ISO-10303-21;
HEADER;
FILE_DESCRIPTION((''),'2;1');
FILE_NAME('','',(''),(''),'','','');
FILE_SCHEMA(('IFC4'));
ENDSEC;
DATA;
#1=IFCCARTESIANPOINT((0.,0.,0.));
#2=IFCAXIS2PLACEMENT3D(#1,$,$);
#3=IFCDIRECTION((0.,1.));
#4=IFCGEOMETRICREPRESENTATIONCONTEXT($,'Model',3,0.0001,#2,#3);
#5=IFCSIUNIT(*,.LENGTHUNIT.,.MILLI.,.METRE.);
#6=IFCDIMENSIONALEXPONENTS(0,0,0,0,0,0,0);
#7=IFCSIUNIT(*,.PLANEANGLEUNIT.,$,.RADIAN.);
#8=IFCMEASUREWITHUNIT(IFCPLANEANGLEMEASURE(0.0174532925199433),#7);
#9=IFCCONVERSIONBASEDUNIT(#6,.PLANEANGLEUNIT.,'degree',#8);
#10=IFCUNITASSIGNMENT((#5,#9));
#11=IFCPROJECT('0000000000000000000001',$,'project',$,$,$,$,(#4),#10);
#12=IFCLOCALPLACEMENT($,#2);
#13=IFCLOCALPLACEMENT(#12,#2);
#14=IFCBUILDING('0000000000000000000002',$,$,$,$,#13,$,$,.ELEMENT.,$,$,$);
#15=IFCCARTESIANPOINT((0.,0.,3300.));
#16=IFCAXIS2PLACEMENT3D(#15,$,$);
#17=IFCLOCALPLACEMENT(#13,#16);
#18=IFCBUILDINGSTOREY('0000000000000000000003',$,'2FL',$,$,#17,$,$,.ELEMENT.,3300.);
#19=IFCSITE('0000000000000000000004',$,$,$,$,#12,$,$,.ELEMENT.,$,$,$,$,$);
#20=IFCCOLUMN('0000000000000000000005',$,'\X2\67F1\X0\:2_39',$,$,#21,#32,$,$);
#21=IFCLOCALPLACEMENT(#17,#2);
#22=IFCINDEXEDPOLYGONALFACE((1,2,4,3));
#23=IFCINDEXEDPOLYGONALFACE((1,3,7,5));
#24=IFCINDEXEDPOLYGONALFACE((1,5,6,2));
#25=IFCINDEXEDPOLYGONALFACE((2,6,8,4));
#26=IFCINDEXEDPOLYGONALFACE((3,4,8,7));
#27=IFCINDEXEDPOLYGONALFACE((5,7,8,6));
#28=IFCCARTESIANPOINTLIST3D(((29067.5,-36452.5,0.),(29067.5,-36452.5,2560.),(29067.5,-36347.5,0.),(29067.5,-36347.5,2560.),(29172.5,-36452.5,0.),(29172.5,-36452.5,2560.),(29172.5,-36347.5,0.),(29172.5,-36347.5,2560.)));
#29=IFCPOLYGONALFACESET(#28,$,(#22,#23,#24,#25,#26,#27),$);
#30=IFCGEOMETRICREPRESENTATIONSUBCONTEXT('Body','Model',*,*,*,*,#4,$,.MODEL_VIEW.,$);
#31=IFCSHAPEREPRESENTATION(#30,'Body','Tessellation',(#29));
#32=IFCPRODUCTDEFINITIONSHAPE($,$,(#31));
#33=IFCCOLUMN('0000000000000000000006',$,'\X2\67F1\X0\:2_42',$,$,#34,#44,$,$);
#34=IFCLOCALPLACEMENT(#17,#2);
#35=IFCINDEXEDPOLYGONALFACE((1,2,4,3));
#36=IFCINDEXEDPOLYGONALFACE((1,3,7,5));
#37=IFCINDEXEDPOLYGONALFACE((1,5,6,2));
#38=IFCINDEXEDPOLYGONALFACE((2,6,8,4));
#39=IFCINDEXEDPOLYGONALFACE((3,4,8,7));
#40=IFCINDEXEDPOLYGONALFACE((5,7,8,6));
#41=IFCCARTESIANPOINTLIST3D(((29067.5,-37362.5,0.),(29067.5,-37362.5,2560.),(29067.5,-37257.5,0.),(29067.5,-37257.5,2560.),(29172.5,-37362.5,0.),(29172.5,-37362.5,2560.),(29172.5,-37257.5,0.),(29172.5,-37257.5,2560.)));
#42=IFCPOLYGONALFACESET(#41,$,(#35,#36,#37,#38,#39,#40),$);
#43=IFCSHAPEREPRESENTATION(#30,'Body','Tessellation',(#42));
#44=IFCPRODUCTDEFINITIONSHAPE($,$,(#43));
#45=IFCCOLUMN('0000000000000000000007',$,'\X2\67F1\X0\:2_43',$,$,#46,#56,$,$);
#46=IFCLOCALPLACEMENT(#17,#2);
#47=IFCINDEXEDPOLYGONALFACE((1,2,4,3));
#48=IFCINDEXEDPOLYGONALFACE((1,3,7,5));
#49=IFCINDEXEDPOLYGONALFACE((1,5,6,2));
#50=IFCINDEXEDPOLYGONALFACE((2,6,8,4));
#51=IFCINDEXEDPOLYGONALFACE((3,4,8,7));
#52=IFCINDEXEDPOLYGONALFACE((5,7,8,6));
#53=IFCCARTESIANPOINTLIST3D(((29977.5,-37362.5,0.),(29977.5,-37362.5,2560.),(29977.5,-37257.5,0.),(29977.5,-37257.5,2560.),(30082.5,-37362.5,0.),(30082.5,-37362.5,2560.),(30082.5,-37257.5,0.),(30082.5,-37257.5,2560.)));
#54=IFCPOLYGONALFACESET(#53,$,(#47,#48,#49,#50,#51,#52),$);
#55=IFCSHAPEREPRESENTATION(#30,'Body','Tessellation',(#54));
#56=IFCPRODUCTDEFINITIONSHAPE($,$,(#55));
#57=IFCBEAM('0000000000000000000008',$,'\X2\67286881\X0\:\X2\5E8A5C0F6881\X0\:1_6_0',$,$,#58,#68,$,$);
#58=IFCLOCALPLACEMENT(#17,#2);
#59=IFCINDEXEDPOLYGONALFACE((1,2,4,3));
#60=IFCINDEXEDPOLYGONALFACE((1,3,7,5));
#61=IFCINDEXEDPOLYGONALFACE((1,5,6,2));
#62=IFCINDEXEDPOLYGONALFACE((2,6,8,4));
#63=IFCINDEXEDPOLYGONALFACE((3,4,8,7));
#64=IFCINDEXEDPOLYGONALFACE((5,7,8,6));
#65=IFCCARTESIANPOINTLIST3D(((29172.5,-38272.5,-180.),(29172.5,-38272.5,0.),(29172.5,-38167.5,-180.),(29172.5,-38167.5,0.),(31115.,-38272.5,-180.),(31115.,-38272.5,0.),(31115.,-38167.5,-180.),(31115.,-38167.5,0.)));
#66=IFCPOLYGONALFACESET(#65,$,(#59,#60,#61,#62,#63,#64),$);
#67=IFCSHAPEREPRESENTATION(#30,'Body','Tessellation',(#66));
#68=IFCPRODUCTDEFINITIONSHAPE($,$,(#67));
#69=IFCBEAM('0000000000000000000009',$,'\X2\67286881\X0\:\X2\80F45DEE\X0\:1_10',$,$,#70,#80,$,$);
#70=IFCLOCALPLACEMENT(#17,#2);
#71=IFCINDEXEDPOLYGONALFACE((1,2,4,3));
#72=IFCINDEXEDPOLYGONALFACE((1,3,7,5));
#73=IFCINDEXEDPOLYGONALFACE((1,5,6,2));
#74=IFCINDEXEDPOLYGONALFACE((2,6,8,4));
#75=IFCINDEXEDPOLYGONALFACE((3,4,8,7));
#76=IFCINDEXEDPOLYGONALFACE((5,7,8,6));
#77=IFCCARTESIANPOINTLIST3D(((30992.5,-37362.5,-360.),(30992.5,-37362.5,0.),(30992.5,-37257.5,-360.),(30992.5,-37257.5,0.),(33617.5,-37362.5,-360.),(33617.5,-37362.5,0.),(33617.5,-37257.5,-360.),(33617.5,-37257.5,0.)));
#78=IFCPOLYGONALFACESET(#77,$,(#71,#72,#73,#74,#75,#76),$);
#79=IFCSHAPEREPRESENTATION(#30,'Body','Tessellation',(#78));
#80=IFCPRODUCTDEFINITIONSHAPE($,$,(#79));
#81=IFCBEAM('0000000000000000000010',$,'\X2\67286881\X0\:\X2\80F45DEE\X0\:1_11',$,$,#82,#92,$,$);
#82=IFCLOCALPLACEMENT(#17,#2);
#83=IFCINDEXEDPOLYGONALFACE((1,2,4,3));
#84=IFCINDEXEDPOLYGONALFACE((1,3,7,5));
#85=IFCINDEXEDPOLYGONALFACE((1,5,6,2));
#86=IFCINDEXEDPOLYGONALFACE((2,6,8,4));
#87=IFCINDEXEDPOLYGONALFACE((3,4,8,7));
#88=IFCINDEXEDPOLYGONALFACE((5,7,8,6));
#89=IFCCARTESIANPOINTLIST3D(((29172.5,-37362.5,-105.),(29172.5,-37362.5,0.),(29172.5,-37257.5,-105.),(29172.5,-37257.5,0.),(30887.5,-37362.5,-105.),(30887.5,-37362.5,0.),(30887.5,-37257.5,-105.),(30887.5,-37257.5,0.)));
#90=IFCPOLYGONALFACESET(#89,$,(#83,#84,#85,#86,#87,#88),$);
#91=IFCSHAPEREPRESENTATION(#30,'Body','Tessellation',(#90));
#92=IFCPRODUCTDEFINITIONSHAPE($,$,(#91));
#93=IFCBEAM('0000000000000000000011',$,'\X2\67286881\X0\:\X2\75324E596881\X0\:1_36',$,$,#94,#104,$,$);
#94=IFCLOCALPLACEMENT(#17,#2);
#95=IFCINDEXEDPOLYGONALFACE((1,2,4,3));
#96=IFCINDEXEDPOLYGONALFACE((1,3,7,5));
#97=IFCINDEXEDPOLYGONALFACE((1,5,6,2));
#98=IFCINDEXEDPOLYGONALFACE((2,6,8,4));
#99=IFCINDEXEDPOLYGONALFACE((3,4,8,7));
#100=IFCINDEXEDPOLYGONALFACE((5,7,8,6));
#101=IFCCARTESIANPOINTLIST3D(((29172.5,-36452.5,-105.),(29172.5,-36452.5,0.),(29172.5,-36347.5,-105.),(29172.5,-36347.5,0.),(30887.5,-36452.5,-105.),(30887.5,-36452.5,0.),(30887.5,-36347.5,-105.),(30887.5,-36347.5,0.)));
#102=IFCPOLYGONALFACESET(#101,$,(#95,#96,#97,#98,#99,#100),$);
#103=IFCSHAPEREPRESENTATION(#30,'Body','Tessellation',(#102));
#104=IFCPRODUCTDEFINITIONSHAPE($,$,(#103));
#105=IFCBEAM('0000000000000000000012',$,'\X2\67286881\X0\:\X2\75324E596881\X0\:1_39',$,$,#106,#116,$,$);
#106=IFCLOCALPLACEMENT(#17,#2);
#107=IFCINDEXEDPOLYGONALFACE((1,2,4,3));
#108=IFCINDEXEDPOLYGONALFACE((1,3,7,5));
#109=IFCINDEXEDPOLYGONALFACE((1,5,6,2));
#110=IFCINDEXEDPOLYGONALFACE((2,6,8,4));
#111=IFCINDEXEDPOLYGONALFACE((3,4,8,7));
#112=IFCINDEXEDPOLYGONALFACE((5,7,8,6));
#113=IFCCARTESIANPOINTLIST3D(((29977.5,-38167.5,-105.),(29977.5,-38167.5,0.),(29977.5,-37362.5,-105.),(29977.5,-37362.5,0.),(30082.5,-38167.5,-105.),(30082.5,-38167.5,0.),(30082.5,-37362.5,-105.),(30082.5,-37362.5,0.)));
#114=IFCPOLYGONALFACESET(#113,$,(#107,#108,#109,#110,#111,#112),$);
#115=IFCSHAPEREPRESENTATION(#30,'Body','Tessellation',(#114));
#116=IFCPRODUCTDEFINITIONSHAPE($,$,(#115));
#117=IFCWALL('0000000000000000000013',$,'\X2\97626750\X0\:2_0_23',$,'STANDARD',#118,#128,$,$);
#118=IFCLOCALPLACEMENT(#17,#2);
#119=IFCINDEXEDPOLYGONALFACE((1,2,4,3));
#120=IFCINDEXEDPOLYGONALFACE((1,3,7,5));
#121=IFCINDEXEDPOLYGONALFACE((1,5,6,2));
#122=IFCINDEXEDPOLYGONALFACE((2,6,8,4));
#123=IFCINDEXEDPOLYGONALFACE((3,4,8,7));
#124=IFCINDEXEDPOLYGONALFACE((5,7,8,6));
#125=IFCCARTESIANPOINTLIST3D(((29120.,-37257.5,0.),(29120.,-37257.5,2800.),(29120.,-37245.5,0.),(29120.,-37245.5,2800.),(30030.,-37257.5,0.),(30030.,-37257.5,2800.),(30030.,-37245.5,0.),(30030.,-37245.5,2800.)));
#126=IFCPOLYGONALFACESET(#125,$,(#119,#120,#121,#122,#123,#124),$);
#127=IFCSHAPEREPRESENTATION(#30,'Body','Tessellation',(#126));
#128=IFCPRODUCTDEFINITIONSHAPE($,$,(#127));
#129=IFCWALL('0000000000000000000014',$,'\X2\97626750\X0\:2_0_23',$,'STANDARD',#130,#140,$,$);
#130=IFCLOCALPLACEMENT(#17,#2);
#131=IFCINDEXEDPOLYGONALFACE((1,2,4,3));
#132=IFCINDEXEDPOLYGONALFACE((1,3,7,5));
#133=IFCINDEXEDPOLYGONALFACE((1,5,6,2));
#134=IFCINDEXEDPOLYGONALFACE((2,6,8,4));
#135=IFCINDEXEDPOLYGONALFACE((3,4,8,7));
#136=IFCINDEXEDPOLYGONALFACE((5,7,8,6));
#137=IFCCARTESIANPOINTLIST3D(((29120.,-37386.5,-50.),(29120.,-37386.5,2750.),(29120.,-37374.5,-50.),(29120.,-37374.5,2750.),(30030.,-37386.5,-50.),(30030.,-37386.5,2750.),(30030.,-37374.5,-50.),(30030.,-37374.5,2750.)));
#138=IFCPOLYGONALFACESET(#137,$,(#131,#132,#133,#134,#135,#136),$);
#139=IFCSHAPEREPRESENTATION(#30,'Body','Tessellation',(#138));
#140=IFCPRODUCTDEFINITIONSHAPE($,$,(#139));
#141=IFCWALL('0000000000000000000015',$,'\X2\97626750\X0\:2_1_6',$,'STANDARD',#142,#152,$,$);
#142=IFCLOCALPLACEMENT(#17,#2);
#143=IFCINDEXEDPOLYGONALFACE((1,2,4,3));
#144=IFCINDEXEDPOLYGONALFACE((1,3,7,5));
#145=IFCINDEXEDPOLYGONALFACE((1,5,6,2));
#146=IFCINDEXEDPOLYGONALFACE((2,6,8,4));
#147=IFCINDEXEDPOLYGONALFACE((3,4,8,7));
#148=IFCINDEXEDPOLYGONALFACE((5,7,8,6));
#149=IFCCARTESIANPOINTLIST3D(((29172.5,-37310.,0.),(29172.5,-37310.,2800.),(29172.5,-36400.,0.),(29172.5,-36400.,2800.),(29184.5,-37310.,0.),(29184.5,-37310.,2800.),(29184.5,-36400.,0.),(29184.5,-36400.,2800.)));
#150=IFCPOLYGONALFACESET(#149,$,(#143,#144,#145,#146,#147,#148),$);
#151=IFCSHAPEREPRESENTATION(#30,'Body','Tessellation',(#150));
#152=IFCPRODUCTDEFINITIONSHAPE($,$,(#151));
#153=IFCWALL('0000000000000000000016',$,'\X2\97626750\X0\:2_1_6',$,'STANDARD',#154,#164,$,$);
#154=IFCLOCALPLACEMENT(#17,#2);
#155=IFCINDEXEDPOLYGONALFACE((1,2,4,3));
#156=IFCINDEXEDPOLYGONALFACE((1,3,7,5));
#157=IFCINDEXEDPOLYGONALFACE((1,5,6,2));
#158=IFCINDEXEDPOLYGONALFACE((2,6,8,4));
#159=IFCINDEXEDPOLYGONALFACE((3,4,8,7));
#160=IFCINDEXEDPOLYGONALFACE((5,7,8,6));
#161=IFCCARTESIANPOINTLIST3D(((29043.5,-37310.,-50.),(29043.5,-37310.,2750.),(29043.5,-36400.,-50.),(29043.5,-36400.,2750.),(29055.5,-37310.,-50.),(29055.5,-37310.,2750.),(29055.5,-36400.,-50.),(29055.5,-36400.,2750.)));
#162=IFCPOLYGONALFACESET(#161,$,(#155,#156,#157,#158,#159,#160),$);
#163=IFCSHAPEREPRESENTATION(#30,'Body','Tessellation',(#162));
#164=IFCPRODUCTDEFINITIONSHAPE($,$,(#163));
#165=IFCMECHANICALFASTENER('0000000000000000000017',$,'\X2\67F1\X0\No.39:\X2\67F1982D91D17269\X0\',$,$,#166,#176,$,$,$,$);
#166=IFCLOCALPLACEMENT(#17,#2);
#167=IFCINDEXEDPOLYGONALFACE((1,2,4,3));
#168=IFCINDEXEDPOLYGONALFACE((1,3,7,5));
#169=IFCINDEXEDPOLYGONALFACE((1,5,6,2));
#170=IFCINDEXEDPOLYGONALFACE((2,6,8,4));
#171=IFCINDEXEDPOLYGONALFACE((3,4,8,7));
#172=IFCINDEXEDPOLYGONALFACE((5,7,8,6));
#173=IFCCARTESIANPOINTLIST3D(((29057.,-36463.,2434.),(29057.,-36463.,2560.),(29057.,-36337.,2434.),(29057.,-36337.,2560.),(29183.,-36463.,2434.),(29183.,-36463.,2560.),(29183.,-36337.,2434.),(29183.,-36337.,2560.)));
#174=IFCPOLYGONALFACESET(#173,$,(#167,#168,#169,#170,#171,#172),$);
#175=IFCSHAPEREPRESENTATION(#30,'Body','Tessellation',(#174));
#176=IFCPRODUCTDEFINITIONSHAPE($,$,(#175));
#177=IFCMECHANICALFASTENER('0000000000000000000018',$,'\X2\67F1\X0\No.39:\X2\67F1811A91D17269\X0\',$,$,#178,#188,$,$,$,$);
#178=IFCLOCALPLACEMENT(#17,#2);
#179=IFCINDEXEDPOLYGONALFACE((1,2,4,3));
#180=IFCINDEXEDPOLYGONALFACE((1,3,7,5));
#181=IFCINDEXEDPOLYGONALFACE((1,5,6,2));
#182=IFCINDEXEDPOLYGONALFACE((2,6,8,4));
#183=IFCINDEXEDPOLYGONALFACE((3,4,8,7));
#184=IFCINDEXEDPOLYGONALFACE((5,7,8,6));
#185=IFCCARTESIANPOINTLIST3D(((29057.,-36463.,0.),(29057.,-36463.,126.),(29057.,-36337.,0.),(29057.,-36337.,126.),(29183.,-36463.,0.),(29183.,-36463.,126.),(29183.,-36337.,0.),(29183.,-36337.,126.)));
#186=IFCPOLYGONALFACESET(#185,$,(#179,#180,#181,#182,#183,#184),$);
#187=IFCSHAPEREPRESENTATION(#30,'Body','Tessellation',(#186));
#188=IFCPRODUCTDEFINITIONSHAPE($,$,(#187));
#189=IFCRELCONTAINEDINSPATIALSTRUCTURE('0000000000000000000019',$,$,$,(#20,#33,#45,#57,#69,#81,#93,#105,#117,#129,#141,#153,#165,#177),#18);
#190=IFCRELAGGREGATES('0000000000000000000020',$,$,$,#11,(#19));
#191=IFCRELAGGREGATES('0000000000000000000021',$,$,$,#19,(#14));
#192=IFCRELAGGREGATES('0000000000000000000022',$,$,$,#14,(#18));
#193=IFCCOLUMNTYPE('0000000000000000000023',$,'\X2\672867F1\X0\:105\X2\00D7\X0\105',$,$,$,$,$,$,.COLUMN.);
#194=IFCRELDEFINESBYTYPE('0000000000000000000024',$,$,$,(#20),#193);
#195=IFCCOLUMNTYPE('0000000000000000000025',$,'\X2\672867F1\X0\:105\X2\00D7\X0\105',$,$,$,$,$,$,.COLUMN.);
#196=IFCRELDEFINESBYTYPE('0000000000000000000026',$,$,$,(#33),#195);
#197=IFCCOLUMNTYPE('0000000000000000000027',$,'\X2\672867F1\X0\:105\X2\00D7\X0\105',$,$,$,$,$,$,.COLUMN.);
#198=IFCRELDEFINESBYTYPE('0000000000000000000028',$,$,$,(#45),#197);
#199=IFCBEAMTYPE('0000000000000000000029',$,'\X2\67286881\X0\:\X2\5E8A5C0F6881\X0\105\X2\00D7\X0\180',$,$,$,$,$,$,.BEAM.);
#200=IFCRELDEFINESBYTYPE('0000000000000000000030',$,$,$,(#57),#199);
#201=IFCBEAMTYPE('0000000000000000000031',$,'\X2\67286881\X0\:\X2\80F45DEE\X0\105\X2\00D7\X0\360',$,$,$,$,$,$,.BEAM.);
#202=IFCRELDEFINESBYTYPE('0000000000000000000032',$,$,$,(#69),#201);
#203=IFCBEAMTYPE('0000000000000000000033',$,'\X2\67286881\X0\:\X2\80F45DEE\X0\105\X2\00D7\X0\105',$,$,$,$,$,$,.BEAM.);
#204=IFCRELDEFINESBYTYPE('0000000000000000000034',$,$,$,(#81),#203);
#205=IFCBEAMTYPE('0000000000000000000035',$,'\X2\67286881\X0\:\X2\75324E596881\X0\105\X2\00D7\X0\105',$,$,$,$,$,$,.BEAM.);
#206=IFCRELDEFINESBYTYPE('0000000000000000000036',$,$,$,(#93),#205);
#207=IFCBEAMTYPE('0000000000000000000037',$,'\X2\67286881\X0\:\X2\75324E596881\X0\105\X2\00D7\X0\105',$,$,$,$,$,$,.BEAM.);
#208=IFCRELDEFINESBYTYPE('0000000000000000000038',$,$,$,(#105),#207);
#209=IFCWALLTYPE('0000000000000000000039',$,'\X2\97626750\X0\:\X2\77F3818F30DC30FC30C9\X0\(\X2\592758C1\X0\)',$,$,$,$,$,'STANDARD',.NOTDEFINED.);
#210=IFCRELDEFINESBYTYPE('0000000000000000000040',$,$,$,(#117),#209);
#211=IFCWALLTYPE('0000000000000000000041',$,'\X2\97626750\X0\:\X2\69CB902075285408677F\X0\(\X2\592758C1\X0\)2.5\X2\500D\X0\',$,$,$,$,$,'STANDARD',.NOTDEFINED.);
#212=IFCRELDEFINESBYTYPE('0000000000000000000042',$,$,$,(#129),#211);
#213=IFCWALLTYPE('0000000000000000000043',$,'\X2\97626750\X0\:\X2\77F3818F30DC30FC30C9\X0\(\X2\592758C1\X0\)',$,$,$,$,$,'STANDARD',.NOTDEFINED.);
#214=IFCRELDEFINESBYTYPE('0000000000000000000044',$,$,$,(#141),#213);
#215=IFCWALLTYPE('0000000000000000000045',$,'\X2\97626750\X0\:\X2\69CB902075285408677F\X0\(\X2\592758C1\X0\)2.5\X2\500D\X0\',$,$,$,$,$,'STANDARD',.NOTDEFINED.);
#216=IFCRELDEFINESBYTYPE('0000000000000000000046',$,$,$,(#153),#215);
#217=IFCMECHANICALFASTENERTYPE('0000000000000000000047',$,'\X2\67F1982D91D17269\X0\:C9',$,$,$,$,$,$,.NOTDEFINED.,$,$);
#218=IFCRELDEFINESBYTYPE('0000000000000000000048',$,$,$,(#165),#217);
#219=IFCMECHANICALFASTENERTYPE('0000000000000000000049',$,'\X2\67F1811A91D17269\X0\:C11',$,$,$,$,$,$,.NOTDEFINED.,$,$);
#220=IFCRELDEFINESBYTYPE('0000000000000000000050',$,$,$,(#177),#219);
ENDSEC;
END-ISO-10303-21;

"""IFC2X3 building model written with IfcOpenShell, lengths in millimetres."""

from ifc_helpers import new_model, entity, si_unit, converted_unit, direction, frame, origin, origin_with_axes, origin_2d, place, context, subcontext, project, spatial, polyline, rectangle, outline, extrude, type_object, element, save


model = new_model("IFC2X3")

# Units and contexts
model_context = context("Model", 3, precision=0.0001, world=origin(), true_north=direction((0.0, 1.0)))
body_context = subcontext(model_context, "Body", "Model", "MODEL_VIEW")
ifc_project = project(units=[si_unit("LENGTHUNIT", "METRE", prefix="MILLI"), converted_unit("PLANEANGLEUNIT", "degree", entity("IfcPlaneAngleMeasure", 0.0174532925199433), si_unit("PLANEANGLEUNIT", "RADIAN"), dimensions=[0, 0, 0, 0, 0, 0, 0])], contexts=[model_context])

# Site, building, storey
site_placement = place(None, origin())
site = spatial("IfcSite", under=ifc_project, at=site_placement, CompositionType="ELEMENT")
building_placement = place(site_placement, origin())
building = spatial("IfcBuilding", under=site, at=building_placement, CompositionType="ELEMENT")
storey_placement = place(building_placement, frame((0.0, 0.0, 3300.0)))
storey = spatial("IfcBuildingStorey", under=building, at=storey_placement, Name="2FL", CompositionType="ELEMENT", Elevation=3300.0)

# Columns
column_type_1 = type_object("IfcColumnType", Name="木柱:105×105", PredefinedType="COLUMN")
column_1_placement = place(storey_placement, frame((29120.0, -36400.0, 0.0)))
element("IfcColumn", 1, at=column_1_placement, inside=storey, type_object=column_type_1, Name="柱:2_39", context=body_context, shape_type="SweptSolid", body=[
    extrude(rectangle(XDim=105.0, YDim=105.0, at=origin_2d()), origin_with_axes(), (0.0, 0.0, 1.0), 2560.0),
])
column_type_2 = type_object("IfcColumnType", Name="木柱:105×105", PredefinedType="COLUMN")
column_2_placement = place(storey_placement, frame((29120.0, -37310.0, 0.0)))
element("IfcColumn", 2, at=column_2_placement, inside=storey, type_object=column_type_2, Name="柱:2_42", context=body_context, shape_type="SweptSolid", body=[
    extrude(rectangle(XDim=105.0, YDim=105.0, at=origin_2d()), origin_with_axes(), (0.0, 0.0, 1.0), 2560.0),
])
column_type_3 = type_object("IfcColumnType", Name="木柱:105×105", PredefinedType="COLUMN")
column_3_placement = place(storey_placement, frame((30030.0, -37310.0, 0.0)))
element("IfcColumn", 3, at=column_3_placement, inside=storey, type_object=column_type_3, Name="柱:2_43", context=body_context, shape_type="SweptSolid", body=[
    extrude(rectangle(XDim=105.0, YDim=105.0, at=origin_2d()), origin_with_axes(), (0.0, 0.0, 1.0), 2560.0),
])

# Beams
beam_type_1 = type_object("IfcBeamType", Name="木梁:床小梁105×180", PredefinedType="BEAM")
beam_1_placement = place(storey_placement, frame((29172.5, -38220.0, -90.0), z_axis=(1.0, 0.0, 0.0), x_axis=(0.0, 1.0, 0.0)))
element("IfcBeam", 4, at=beam_1_placement, inside=storey, type_object=beam_type_1, Name="木梁:床小梁:1_6_0", context=body_context, shape_type="SweptSolid", body=[
    extrude(rectangle(XDim=105.0, YDim=180.0, at=origin_2d()), origin_with_axes(), (0.0, 0.0, 1.0), 1942.5),
])
beam_type_2 = type_object("IfcBeamType", Name="木梁:胴差105×360", PredefinedType="BEAM")
beam_2_placement = place(storey_placement, frame((30992.5, -37310.0, -180.0), z_axis=(1.0, 0.0, 0.0), x_axis=(0.0, 1.0, 0.0)))
element("IfcBeam", 5, at=beam_2_placement, inside=storey, type_object=beam_type_2, Name="木梁:胴差:1_10", context=body_context, shape_type="SweptSolid", body=[
    extrude(rectangle(XDim=105.0, YDim=360.0, at=origin_2d()), origin_with_axes(), (0.0, 0.0, 1.0), 2625.0),
])
beam_type_3 = type_object("IfcBeamType", Name="木梁:胴差105×105", PredefinedType="BEAM")
beam_3_placement = place(storey_placement, frame((29172.5, -37310.0, -52.5), z_axis=(1.0, 0.0, 0.0), x_axis=(0.0, 1.0, 0.0)))
element("IfcBeam", 6, at=beam_3_placement, inside=storey, type_object=beam_type_3, Name="木梁:胴差:1_11", context=body_context, shape_type="SweptSolid", body=[
    extrude(rectangle(XDim=105.0, YDim=105.0, at=origin_2d()), origin_with_axes(), (0.0, 0.0, 1.0), 1715.0),
])
beam_type_4 = type_object("IfcBeamType", Name="木梁:甲乙梁105×105", PredefinedType="BEAM")
beam_4_placement = place(storey_placement, frame((29172.5, -36400.0, -52.5), z_axis=(1.0, 0.0, 0.0), x_axis=(0.0, 1.0, 0.0)))
element("IfcBeam", 7, at=beam_4_placement, inside=storey, type_object=beam_type_4, Name="木梁:甲乙梁:1_36", context=body_context, shape_type="SweptSolid", body=[
    extrude(rectangle(XDim=105.0, YDim=105.0, at=origin_2d()), origin_with_axes(), (0.0, 0.0, 1.0), 1715.0),
])
beam_type_5 = type_object("IfcBeamType", Name="木梁:甲乙梁105×105", PredefinedType="BEAM")
beam_5_placement = place(storey_placement, frame((30030.0, -37362.5, -52.5), z_axis=(0.0, -1.0, 0.0), x_axis=(1.0, 0.0, 0.0)))
element("IfcBeam", 8, at=beam_5_placement, inside=storey, type_object=beam_type_5, Name="木梁:甲乙梁:1_39", context=body_context, shape_type="SweptSolid", body=[
    extrude(rectangle(XDim=105.0, YDim=105.0, at=origin_2d()), origin_with_axes(), (0.0, 0.0, 1.0), 805.0),
])

# Walls
wall_type_1 = type_object("IfcWallType", Name="面材:石膏ボード(大壁)", ElementType="STANDARD", PredefinedType="NOTDEFINED")
wall_1_placement = place(storey_placement, frame((29575.0, -37245.5, 0.0), z_axis=(0.0, -1.0, 0.0), x_axis=(1.0, 0.0, 0.0)))
element("IfcWall", 9, at=wall_1_placement, inside=storey, type_object=wall_type_1, Name="面材:2_0_23", ObjectType="STANDARD", context=body_context, shape_type="SweptSolid", body=[
    extrude(outline(polyline([(455.0, 0.0, 0.0), (-455.0, 0.0, 0.0), (-455.0, 2800.0, 0.0), (455.0, 2800.0, 0.0), (455.0, 0.0, 0.0)])), origin_with_axes(), (0.0, 0.0, 1.0), 12.0),
])
wall_type_2 = type_object("IfcWallType", Name="面材:構造用合板(大壁)2.5倍", ElementType="STANDARD", PredefinedType="NOTDEFINED")
wall_2_placement = place(storey_placement, frame((29575.0, -37374.5, -50.0), z_axis=(0.0, -1.0, 0.0), x_axis=(1.0, 0.0, 0.0)))
element("IfcWall", 10, at=wall_2_placement, inside=storey, type_object=wall_type_2, Name="面材:2_0_23", ObjectType="STANDARD", context=body_context, shape_type="SweptSolid", body=[
    extrude(outline(polyline([(455.0, 0.0, 0.0), (-455.0, 0.0, 0.0), (-455.0, 2800.0, 0.0), (455.0, 2800.0, 0.0), (455.0, 0.0, 0.0)])), origin_with_axes(), (0.0, 0.0, 1.0), 12.0),
])
wall_type_3 = type_object("IfcWallType", Name="面材:石膏ボード(大壁)", ElementType="STANDARD", PredefinedType="NOTDEFINED")
wall_3_placement = place(storey_placement, frame((29184.5, -36855.0, 0.0), z_axis=(-1.0, 0.0, 0.0), x_axis=(0.0, -1.0, 0.0)))
element("IfcWall", 11, at=wall_3_placement, inside=storey, type_object=wall_type_3, Name="面材:2_1_6", ObjectType="STANDARD", context=body_context, shape_type="SweptSolid", body=[
    extrude(outline(polyline([(455.0, 0.0, 0.0), (-455.0, 0.0, 0.0), (-455.0, 2800.0, 0.0), (455.0, 2800.0, 0.0), (455.0, 0.0, 0.0)])), origin_with_axes(), (0.0, 0.0, 1.0), 12.0),
])
wall_type_4 = type_object("IfcWallType", Name="面材:構造用合板(大壁)2.5倍", ElementType="STANDARD", PredefinedType="NOTDEFINED")
wall_4_placement = place(storey_placement, frame((29055.5, -36855.0, -50.0), z_axis=(-1.0, 0.0, 0.0), x_axis=(0.0, -1.0, 0.0)))
element("IfcWall", 12, at=wall_4_placement, inside=storey, type_object=wall_type_4, Name="面材:2_1_6", ObjectType="STANDARD", context=body_context, shape_type="SweptSolid", body=[
    extrude(outline(polyline([(455.0, 0.0, 0.0), (-455.0, 0.0, 0.0), (-455.0, 2800.0, 0.0), (455.0, 2800.0, 0.0), (455.0, 0.0, 0.0)])), origin_with_axes(), (0.0, 0.0, 1.0), 12.0),
])

# Mechanical fasteners
mechanical_fastener_type_1 = type_object("IfcMechanicalFastenerType", Name="柱頭金物:C9")
mechanical_fastener_1_placement = place(storey_placement, frame((29120.0, -36400.0, 2434.0)))
element("IfcMechanicalFastener", 13, at=mechanical_fastener_1_placement, inside=storey, type_object=mechanical_fastener_type_1, Name="柱No.39:柱頭金物", context=body_context, shape_type="SweptSolid", body=[
    extrude(rectangle(XDim=126.0, YDim=126.0, at=origin_2d()), origin_with_axes(), (0.0, 0.0, 1.0), 126.0),
])
mechanical_fastener_type_2 = type_object("IfcMechanicalFastenerType", Name="柱脚金物:C11")
mechanical_fastener_2_placement = place(storey_placement, frame((29120.0, -36400.0, 0.0)))
element("IfcMechanicalFastener", 14, at=mechanical_fastener_2_placement, inside=storey, type_object=mechanical_fastener_type_2, Name="柱No.39:柱脚金物", context=body_context, shape_type="SweptSolid", body=[
    extrude(rectangle(XDim=126.0, YDim=126.0, at=origin_2d()), origin_with_axes(), (0.0, 0.0, 1.0), 126.0),
])

save(model, "model.ifc")
